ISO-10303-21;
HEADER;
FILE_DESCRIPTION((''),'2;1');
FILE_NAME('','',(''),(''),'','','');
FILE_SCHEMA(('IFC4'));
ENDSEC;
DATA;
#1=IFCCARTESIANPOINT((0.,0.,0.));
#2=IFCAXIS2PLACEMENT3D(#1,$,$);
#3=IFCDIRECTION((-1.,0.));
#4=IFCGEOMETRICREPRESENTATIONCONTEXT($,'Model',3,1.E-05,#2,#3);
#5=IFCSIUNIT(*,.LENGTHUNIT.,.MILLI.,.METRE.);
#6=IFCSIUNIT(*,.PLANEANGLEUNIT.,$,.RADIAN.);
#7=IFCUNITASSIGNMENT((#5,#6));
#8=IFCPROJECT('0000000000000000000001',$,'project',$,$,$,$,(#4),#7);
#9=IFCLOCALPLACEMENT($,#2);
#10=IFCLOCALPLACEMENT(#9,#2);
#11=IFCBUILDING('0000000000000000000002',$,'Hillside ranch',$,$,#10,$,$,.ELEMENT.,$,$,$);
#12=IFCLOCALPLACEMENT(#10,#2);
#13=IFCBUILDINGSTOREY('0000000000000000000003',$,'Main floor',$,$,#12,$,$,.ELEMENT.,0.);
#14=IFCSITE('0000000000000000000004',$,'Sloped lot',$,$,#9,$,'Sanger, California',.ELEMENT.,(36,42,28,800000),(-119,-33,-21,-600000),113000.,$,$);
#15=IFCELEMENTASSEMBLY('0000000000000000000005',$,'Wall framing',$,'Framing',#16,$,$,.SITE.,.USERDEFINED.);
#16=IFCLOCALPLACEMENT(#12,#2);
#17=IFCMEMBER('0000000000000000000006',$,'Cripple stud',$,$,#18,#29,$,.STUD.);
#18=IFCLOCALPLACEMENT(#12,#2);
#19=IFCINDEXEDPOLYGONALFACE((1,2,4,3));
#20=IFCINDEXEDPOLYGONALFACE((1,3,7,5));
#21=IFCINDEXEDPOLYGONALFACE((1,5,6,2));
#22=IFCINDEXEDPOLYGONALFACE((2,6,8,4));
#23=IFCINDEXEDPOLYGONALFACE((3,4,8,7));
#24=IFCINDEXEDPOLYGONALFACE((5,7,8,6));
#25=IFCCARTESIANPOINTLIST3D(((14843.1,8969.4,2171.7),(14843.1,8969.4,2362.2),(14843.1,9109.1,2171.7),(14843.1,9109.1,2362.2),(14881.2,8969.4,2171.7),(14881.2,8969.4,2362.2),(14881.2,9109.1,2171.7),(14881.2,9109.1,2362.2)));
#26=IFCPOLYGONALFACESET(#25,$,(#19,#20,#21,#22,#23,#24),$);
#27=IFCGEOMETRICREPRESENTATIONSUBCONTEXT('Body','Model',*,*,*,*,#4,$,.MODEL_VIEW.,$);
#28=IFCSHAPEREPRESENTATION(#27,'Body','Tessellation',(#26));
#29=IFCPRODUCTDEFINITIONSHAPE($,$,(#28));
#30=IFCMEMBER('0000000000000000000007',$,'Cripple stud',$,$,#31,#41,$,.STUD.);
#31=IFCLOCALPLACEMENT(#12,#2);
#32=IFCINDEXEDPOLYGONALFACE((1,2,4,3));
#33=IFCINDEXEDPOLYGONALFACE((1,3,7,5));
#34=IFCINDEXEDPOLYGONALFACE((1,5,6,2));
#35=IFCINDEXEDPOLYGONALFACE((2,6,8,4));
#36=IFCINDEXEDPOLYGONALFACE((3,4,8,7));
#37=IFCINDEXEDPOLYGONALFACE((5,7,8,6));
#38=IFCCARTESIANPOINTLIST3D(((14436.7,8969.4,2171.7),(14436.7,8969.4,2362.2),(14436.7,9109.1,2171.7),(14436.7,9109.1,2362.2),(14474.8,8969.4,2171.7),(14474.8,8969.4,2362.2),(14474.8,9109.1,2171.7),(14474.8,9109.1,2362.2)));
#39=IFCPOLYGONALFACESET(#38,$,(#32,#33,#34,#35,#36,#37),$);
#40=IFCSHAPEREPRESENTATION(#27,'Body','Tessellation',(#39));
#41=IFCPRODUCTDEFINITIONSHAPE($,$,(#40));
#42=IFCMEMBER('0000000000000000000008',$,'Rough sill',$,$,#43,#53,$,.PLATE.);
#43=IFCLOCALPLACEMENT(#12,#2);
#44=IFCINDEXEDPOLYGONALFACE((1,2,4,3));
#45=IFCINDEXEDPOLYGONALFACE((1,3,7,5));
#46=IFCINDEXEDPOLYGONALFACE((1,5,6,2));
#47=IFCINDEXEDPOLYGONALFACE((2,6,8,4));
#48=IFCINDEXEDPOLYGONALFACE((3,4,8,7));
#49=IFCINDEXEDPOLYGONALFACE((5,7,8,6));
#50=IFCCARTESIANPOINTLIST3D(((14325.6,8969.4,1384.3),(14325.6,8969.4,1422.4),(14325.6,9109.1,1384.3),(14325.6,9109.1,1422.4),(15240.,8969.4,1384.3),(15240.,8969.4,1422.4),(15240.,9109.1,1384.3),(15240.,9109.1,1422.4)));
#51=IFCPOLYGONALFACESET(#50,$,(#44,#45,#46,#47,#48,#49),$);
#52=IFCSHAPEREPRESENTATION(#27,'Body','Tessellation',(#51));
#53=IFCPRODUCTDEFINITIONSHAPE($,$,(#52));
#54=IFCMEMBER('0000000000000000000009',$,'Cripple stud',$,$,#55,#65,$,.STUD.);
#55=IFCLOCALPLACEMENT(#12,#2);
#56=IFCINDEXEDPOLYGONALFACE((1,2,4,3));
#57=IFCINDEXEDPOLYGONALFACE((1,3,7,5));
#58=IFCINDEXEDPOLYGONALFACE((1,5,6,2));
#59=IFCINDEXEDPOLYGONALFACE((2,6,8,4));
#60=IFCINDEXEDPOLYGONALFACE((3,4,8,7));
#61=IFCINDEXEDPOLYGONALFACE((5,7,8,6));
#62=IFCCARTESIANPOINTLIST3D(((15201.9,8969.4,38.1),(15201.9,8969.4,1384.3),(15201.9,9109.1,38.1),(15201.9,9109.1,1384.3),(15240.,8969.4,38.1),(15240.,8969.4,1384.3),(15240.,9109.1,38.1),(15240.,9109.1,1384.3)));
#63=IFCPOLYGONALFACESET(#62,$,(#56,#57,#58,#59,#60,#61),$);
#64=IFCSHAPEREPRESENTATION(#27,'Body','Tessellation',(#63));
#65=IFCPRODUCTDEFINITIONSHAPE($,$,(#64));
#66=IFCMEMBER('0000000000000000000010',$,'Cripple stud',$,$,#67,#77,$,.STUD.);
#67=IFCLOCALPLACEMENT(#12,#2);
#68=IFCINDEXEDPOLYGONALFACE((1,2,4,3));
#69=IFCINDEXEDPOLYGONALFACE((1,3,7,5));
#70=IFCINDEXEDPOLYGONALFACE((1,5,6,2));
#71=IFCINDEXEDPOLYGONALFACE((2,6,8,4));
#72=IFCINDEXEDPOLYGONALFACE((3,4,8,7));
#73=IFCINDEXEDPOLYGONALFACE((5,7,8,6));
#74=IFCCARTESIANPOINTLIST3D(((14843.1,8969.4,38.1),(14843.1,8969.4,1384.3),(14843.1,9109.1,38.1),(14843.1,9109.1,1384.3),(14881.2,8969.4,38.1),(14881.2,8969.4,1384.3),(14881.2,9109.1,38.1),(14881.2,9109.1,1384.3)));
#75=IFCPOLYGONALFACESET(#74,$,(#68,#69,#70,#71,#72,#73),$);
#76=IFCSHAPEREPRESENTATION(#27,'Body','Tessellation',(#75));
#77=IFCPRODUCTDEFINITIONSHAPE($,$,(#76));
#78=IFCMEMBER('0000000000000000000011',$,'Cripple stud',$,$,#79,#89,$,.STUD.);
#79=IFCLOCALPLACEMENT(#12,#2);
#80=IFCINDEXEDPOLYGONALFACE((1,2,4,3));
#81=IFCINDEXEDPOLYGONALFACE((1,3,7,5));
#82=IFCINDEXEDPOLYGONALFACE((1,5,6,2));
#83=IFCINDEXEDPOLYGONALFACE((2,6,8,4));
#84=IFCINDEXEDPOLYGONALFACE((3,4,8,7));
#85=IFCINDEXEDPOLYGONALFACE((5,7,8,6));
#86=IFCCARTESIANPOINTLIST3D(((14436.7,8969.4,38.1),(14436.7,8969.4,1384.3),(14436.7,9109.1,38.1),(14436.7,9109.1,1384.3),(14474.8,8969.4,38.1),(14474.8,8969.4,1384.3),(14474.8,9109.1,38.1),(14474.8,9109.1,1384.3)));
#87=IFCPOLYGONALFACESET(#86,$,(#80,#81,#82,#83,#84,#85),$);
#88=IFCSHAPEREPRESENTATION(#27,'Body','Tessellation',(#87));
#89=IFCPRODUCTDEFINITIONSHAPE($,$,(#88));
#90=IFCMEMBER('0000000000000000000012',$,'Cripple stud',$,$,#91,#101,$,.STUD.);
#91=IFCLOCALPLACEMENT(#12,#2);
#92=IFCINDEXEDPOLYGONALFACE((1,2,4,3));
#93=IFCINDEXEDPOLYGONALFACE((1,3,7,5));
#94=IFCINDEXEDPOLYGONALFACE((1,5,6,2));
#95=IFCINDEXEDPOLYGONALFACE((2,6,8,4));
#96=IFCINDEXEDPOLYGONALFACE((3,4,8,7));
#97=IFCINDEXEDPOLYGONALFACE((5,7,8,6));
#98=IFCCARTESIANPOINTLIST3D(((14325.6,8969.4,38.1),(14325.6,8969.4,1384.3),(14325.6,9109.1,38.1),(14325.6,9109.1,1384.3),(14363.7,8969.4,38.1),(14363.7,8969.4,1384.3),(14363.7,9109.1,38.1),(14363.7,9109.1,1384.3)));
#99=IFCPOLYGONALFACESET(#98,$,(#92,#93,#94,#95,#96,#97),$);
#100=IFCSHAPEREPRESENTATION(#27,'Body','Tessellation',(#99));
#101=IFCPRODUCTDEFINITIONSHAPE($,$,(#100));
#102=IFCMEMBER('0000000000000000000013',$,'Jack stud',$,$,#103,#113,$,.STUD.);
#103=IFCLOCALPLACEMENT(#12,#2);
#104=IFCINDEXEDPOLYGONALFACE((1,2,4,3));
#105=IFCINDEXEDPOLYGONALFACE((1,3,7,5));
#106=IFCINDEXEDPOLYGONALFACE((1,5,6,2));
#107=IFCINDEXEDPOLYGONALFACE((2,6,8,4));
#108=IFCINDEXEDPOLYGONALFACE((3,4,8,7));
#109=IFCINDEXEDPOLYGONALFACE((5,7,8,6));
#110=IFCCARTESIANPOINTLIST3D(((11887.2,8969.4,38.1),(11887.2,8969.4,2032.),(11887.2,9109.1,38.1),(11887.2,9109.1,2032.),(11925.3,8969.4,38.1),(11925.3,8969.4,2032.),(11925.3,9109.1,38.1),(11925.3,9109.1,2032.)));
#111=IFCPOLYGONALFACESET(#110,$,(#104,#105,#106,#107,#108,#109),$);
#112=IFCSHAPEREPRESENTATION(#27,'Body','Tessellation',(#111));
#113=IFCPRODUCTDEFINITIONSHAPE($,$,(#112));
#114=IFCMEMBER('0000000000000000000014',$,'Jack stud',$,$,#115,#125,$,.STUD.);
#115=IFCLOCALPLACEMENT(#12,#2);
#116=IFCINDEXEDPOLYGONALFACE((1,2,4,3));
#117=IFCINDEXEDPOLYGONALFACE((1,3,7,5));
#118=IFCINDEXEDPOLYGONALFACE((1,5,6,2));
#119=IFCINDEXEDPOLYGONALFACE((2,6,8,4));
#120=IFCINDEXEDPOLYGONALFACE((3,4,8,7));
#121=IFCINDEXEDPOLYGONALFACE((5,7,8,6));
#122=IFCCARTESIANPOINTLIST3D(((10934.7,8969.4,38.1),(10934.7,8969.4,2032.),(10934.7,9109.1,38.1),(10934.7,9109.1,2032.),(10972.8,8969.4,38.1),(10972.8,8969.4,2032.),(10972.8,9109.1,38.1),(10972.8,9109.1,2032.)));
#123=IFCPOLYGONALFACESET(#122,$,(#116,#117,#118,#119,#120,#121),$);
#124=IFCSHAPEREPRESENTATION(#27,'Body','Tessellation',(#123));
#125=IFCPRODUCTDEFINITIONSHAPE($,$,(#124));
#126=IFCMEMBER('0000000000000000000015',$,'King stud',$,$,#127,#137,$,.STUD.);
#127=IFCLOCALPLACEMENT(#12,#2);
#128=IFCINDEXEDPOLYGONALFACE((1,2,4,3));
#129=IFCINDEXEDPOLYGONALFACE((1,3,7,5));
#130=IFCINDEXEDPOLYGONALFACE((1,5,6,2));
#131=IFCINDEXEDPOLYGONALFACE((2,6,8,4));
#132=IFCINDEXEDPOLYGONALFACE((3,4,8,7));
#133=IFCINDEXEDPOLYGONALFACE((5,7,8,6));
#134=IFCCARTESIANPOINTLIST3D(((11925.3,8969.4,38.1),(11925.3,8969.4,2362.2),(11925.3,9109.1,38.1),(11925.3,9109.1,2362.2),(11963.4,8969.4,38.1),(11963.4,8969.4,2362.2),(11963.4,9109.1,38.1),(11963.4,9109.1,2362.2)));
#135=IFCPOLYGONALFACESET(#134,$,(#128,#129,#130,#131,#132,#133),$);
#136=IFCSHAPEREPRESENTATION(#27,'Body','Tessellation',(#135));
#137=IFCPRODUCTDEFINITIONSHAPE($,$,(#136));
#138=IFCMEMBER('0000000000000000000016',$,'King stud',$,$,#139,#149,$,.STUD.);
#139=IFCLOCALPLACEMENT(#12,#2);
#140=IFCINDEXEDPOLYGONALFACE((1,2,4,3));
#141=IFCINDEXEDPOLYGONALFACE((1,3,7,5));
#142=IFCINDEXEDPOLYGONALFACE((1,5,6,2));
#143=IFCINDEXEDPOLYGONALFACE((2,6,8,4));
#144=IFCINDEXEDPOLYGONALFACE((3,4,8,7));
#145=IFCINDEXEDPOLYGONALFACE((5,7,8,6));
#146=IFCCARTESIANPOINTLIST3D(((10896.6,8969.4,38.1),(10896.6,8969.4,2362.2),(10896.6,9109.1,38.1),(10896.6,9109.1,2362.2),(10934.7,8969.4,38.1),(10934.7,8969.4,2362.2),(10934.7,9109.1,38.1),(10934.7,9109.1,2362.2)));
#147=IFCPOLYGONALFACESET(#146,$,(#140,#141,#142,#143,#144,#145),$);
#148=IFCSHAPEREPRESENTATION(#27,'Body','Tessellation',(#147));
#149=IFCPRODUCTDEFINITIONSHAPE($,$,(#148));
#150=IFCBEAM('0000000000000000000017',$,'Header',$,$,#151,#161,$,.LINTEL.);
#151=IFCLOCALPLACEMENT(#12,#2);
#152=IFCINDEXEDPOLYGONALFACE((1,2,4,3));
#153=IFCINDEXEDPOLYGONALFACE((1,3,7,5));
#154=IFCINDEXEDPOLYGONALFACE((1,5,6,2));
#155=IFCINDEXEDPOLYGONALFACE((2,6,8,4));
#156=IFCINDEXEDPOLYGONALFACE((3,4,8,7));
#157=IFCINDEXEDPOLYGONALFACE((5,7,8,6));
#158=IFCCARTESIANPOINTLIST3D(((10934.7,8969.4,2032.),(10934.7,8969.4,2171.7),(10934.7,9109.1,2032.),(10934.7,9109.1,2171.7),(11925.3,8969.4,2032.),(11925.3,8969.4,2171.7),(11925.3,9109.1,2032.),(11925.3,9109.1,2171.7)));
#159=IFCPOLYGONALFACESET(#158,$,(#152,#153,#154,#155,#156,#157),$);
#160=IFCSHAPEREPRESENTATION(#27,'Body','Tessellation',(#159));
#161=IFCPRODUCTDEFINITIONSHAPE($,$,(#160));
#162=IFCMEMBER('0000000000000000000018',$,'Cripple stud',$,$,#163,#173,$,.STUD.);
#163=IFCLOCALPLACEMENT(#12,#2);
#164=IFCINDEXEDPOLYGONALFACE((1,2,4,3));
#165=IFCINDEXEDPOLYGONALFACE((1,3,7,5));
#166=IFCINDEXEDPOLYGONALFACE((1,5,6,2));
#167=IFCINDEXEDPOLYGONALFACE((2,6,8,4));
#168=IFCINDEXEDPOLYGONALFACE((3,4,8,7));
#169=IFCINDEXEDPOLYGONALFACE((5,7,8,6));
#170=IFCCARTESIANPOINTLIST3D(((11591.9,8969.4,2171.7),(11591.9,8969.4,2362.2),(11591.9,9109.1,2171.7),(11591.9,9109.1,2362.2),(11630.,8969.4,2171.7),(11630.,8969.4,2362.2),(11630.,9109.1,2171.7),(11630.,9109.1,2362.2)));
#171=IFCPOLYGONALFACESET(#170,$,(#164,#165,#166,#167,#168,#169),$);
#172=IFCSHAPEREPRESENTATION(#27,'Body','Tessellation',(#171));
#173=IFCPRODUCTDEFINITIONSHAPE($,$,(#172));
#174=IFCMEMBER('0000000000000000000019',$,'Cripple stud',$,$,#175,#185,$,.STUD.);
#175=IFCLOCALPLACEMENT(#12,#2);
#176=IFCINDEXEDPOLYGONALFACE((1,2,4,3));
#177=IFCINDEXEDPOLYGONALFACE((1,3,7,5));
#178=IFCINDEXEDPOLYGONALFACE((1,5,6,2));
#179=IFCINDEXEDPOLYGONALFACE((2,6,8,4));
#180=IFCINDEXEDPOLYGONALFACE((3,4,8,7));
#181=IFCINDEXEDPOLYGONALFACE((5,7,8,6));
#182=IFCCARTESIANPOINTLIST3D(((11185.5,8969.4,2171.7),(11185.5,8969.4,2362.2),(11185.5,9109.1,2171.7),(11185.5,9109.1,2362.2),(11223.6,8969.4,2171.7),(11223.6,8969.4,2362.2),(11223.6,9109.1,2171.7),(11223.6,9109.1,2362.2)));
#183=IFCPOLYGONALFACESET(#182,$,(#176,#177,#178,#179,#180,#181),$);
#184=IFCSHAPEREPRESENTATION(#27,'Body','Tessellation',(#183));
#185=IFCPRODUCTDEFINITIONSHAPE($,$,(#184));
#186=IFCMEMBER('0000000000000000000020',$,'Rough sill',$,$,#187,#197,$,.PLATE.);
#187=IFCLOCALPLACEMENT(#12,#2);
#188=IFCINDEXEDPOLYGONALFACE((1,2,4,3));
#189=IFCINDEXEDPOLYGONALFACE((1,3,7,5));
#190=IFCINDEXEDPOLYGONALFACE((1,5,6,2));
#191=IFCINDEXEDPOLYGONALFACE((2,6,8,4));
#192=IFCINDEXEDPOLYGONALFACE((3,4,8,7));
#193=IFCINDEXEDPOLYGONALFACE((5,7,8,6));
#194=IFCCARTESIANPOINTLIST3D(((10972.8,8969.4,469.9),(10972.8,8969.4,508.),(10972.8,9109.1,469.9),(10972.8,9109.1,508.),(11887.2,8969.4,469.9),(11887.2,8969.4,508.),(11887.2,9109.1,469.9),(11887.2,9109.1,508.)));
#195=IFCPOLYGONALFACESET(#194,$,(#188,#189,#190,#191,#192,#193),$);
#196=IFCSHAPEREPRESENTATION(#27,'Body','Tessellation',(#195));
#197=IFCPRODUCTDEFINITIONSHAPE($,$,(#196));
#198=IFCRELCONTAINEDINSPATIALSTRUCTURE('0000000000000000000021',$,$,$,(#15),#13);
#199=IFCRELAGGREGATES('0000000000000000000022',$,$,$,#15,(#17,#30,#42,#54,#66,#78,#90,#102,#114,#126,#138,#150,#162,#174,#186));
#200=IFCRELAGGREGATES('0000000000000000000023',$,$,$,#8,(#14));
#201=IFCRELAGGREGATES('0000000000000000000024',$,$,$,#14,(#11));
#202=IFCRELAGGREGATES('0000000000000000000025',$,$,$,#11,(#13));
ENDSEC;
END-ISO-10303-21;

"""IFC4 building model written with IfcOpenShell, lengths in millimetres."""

from ifc_helpers import new_model, si_unit, direction, frame, origin, origin_with_axes, place, context, subcontext, project, spatial, polyline, outline, extrude, element, aggregate, save


model = new_model("IFC4")

# Units and contexts
model_context = context("Model", 3, precision=1e-05, world=origin(), true_north=direction((-1.0, 0.0)))
body_context = subcontext(model_context, "Body", "Model", "MODEL_VIEW")
ifc_project = project(units=[si_unit("LENGTHUNIT", "METRE", prefix="MILLI"), si_unit("PLANEANGLEUNIT", "RADIAN")], contexts=[model_context])

# Site, building, storey
site_placement = place(None, origin())
site = spatial("IfcSite", under=ifc_project, at=site_placement, Name="Sloped lot", LongName="Sanger, California", CompositionType="ELEMENT", RefLatitude=(36, 42, 28, 800000), RefLongitude=(-119, -33, -21, -600000), RefElevation=113000.0)
building_placement = place(site_placement, origin())
building = spatial("IfcBuilding", under=site, at=building_placement, Name="Hillside ranch", CompositionType="ELEMENT")
storey_placement = place(building_placement, origin())
storey = spatial("IfcBuildingStorey", under=building, at=storey_placement, Name="Main floor", CompositionType="ELEMENT", Elevation=0.0)

# Element assembly, members, beam
assembly_placement = place(storey_placement, origin_with_axes())
assembly = element("IfcElementAssembly", 1, at=assembly_placement, inside=storey, Name="Wall framing", ObjectType="Framing", AssemblyPlace="SITE", PredefinedType="USERDEFINED")
member_1_placement = place(storey_placement, origin_with_axes())
member_1 = element("IfcMember", 2, at=member_1_placement, Name="Cripple stud", PredefinedType="STUD", context=body_context, shape_type="SweptSolid", body=[
    extrude(outline(polyline([(0.0, 0.0), (38.1, 0.0), (38.1, 139.7), (0.0, 139.7), (0.0, 0.0)])), frame((14881.2, 9109.1, 2171.7), z_axis=(0.0, 0.0, 1.0), x_axis=(-1.0, 0.0, 0.0)), (0.0, 0.0, 1.0), 190.5),
])
member_2_placement = place(storey_placement, origin_with_axes())
member_2 = element("IfcMember", 3, at=member_2_placement, Name="Cripple stud", PredefinedType="STUD", context=body_context, shape_type="SweptSolid", body=[
    extrude(outline(polyline([(0.0, 0.0), (38.1, 0.0), (38.1, 139.7), (0.0, 139.7), (0.0, 0.0)])), frame((14474.8, 9109.1, 2171.7), z_axis=(0.0, 0.0, 1.0), x_axis=(-1.0, 0.0, 0.0)), (0.0, 0.0, 1.0), 190.5),
])
member_3_placement = place(storey_placement, origin_with_axes())
member_3 = element("IfcMember", 4, at=member_3_placement, Name="Rough sill", PredefinedType="PLATE", context=body_context, shape_type="SweptSolid", body=[
    extrude(outline(polyline([(0.0, 0.0), (914.4, 0.0), (914.4, 139.7), (0.0, 139.7), (0.0, 0.0)])), frame((15240.0, 9109.1, 1384.3), z_axis=(0.0, 0.0, 1.0), x_axis=(-1.0, 0.0, 0.0)), (0.0, 0.0, 1.0), 38.1),
])
member_4_placement = place(storey_placement, origin_with_axes())
member_4 = element("IfcMember", 5, at=member_4_placement, Name="Cripple stud", PredefinedType="STUD", context=body_context, shape_type="SweptSolid", body=[
    extrude(outline(polyline([(0.0, 0.0), (38.1, 0.0), (38.1, 139.7), (0.0, 139.7), (0.0, 0.0)])), frame((15240.0, 9109.1, 38.1), z_axis=(0.0, 0.0, 1.0), x_axis=(-1.0, 0.0, 0.0)), (0.0, 0.0, 1.0), 1346.2),
])
member_5_placement = place(storey_placement, origin_with_axes())
member_5 = element("IfcMember", 6, at=member_5_placement, Name="Cripple stud", PredefinedType="STUD", context=body_context, shape_type="SweptSolid", body=[
    extrude(outline(polyline([(0.0, 0.0), (38.1, 0.0), (38.1, 139.7), (0.0, 139.7), (0.0, 0.0)])), frame((14881.2, 9109.1, 38.1), z_axis=(0.0, 0.0, 1.0), x_axis=(-1.0, 0.0, 0.0)), (0.0, 0.0, 1.0), 1346.2),
])
member_6_placement = place(storey_placement, origin_with_axes())
member_6 = element("IfcMember", 7, at=member_6_placement, Name="Cripple stud", PredefinedType="STUD", context=body_context, shape_type="SweptSolid", body=[
    extrude(outline(polyline([(0.0, 0.0), (38.1, 0.0), (38.1, 139.7), (0.0, 139.7), (0.0, 0.0)])), frame((14474.8, 9109.1, 38.1), z_axis=(0.0, 0.0, 1.0), x_axis=(-1.0, 0.0, 0.0)), (0.0, 0.0, 1.0), 1346.2),
])
member_7_placement = place(storey_placement, origin_with_axes())
member_7 = element("IfcMember", 8, at=member_7_placement, Name="Cripple stud", PredefinedType="STUD", context=body_context, shape_type="SweptSolid", body=[
    extrude(outline(polyline([(0.0, 0.0), (38.1, 0.0), (38.1, 139.7), (0.0, 139.7), (0.0, 0.0)])), frame((14363.7, 9109.1, 38.1), z_axis=(0.0, 0.0, 1.0), x_axis=(-1.0, 0.0, 0.0)), (0.0, 0.0, 1.0), 1346.2),
])
member_8_placement = place(storey_placement, origin_with_axes())
member_8 = element("IfcMember", 9, at=member_8_placement, Name="Jack stud", PredefinedType="STUD", context=body_context, shape_type="SweptSolid", body=[
    extrude(outline(polyline([(0.0, 0.0), (38.1, 0.0), (38.1, 139.7), (0.0, 139.7), (0.0, 0.0)])), frame((11925.3, 9109.1, 38.1), z_axis=(0.0, 0.0, 1.0), x_axis=(-1.0, 0.0, 0.0)), (0.0, 0.0, 1.0), 1993.9),
])
member_9_placement = place(storey_placement, origin_with_axes())
member_9 = element("IfcMember", 10, at=member_9_placement, Name="Jack stud", PredefinedType="STUD", context=body_context, shape_type="SweptSolid", body=[
    extrude(outline(polyline([(0.0, 0.0), (38.1, 0.0), (38.1, 139.7), (0.0, 139.7), (0.0, 0.0)])), frame((10972.8, 9109.1, 38.1), z_axis=(0.0, 0.0, 1.0), x_axis=(-1.0, 0.0, 0.0)), (0.0, 0.0, 1.0), 1993.9),
])
member_10_placement = place(storey_placement, origin_with_axes())
member_10 = element("IfcMember", 11, at=member_10_placement, Name="King stud", PredefinedType="STUD", context=body_context, shape_type="SweptSolid", body=[
    extrude(outline(polyline([(0.0, 0.0), (38.1, 0.0), (38.1, 139.7), (0.0, 139.7), (0.0, 0.0)])), frame((11963.4, 9109.1, 38.1), z_axis=(0.0, 0.0, 1.0), x_axis=(-1.0, 0.0, 0.0)), (0.0, 0.0, 1.0), 2324.1),
])
member_11_placement = place(storey_placement, origin_with_axes())
member_11 = element("IfcMember", 12, at=member_11_placement, Name="King stud", PredefinedType="STUD", context=body_context, shape_type="SweptSolid", body=[
    extrude(outline(polyline([(0.0, 0.0), (38.1, 0.0), (38.1, 139.7), (0.0, 139.7), (0.0, 0.0)])), frame((10934.7, 9109.1, 38.1), z_axis=(0.0, 0.0, 1.0), x_axis=(-1.0, 0.0, 0.0)), (0.0, 0.0, 1.0), 2324.1),
])
beam_placement = place(storey_placement, origin_with_axes())
beam = element("IfcBeam", 13, at=beam_placement, Name="Header", PredefinedType="LINTEL", context=body_context, shape_type="SweptSolid", body=[
    extrude(outline(polyline([(0.0, 0.0), (990.6, 0.0), (990.6, 139.7), (0.0, 139.7), (0.0, 0.0)])), frame((11925.3, 9109.1, 2032.0), z_axis=(0.0, 0.0, 1.0), x_axis=(-1.0, 0.0, 0.0)), (0.0, 0.0, 1.0), 139.7),
])
member_12_placement = place(storey_placement, origin_with_axes())
member_12 = element("IfcMember", 14, at=member_12_placement, Name="Cripple stud", PredefinedType="STUD", context=body_context, shape_type="SweptSolid", body=[
    extrude(outline(polyline([(0.0, 0.0), (38.1, 0.0), (38.1, 139.7), (0.0, 139.7), (0.0, 0.0)])), frame((11630.0, 9109.1, 2171.7), z_axis=(0.0, 0.0, 1.0), x_axis=(-1.0, 0.0, 0.0)), (0.0, 0.0, 1.0), 190.5),
])
member_13_placement = place(storey_placement, origin_with_axes())
member_13 = element("IfcMember", 15, at=member_13_placement, Name="Cripple stud", PredefinedType="STUD", context=body_context, shape_type="SweptSolid", body=[
    extrude(outline(polyline([(0.0, 0.0), (38.1, 0.0), (38.1, 139.7), (0.0, 139.7), (0.0, 0.0)])), frame((11223.6, 9109.1, 2171.7), z_axis=(0.0, 0.0, 1.0), x_axis=(-1.0, 0.0, 0.0)), (0.0, 0.0, 1.0), 190.5),
])
member_14_placement = place(storey_placement, origin_with_axes())
member_14 = element("IfcMember", 16, at=member_14_placement, Name="Rough sill", PredefinedType="PLATE", context=body_context, shape_type="SweptSolid", body=[
    extrude(outline(polyline([(0.0, 0.0), (914.4, 0.0), (914.4, 139.7), (0.0, 139.7), (0.0, 0.0)])), frame((11887.2, 9109.1, 469.9), z_axis=(0.0, 0.0, 1.0), x_axis=(-1.0, 0.0, 0.0)), (0.0, 0.0, 1.0), 38.1),
])
aggregate(assembly, [member_1, member_2, member_3, member_4, member_5, member_6, member_7, member_8, member_9, member_10, member_11, beam, member_12, member_13, member_14])

save(model, "model.ifc")
